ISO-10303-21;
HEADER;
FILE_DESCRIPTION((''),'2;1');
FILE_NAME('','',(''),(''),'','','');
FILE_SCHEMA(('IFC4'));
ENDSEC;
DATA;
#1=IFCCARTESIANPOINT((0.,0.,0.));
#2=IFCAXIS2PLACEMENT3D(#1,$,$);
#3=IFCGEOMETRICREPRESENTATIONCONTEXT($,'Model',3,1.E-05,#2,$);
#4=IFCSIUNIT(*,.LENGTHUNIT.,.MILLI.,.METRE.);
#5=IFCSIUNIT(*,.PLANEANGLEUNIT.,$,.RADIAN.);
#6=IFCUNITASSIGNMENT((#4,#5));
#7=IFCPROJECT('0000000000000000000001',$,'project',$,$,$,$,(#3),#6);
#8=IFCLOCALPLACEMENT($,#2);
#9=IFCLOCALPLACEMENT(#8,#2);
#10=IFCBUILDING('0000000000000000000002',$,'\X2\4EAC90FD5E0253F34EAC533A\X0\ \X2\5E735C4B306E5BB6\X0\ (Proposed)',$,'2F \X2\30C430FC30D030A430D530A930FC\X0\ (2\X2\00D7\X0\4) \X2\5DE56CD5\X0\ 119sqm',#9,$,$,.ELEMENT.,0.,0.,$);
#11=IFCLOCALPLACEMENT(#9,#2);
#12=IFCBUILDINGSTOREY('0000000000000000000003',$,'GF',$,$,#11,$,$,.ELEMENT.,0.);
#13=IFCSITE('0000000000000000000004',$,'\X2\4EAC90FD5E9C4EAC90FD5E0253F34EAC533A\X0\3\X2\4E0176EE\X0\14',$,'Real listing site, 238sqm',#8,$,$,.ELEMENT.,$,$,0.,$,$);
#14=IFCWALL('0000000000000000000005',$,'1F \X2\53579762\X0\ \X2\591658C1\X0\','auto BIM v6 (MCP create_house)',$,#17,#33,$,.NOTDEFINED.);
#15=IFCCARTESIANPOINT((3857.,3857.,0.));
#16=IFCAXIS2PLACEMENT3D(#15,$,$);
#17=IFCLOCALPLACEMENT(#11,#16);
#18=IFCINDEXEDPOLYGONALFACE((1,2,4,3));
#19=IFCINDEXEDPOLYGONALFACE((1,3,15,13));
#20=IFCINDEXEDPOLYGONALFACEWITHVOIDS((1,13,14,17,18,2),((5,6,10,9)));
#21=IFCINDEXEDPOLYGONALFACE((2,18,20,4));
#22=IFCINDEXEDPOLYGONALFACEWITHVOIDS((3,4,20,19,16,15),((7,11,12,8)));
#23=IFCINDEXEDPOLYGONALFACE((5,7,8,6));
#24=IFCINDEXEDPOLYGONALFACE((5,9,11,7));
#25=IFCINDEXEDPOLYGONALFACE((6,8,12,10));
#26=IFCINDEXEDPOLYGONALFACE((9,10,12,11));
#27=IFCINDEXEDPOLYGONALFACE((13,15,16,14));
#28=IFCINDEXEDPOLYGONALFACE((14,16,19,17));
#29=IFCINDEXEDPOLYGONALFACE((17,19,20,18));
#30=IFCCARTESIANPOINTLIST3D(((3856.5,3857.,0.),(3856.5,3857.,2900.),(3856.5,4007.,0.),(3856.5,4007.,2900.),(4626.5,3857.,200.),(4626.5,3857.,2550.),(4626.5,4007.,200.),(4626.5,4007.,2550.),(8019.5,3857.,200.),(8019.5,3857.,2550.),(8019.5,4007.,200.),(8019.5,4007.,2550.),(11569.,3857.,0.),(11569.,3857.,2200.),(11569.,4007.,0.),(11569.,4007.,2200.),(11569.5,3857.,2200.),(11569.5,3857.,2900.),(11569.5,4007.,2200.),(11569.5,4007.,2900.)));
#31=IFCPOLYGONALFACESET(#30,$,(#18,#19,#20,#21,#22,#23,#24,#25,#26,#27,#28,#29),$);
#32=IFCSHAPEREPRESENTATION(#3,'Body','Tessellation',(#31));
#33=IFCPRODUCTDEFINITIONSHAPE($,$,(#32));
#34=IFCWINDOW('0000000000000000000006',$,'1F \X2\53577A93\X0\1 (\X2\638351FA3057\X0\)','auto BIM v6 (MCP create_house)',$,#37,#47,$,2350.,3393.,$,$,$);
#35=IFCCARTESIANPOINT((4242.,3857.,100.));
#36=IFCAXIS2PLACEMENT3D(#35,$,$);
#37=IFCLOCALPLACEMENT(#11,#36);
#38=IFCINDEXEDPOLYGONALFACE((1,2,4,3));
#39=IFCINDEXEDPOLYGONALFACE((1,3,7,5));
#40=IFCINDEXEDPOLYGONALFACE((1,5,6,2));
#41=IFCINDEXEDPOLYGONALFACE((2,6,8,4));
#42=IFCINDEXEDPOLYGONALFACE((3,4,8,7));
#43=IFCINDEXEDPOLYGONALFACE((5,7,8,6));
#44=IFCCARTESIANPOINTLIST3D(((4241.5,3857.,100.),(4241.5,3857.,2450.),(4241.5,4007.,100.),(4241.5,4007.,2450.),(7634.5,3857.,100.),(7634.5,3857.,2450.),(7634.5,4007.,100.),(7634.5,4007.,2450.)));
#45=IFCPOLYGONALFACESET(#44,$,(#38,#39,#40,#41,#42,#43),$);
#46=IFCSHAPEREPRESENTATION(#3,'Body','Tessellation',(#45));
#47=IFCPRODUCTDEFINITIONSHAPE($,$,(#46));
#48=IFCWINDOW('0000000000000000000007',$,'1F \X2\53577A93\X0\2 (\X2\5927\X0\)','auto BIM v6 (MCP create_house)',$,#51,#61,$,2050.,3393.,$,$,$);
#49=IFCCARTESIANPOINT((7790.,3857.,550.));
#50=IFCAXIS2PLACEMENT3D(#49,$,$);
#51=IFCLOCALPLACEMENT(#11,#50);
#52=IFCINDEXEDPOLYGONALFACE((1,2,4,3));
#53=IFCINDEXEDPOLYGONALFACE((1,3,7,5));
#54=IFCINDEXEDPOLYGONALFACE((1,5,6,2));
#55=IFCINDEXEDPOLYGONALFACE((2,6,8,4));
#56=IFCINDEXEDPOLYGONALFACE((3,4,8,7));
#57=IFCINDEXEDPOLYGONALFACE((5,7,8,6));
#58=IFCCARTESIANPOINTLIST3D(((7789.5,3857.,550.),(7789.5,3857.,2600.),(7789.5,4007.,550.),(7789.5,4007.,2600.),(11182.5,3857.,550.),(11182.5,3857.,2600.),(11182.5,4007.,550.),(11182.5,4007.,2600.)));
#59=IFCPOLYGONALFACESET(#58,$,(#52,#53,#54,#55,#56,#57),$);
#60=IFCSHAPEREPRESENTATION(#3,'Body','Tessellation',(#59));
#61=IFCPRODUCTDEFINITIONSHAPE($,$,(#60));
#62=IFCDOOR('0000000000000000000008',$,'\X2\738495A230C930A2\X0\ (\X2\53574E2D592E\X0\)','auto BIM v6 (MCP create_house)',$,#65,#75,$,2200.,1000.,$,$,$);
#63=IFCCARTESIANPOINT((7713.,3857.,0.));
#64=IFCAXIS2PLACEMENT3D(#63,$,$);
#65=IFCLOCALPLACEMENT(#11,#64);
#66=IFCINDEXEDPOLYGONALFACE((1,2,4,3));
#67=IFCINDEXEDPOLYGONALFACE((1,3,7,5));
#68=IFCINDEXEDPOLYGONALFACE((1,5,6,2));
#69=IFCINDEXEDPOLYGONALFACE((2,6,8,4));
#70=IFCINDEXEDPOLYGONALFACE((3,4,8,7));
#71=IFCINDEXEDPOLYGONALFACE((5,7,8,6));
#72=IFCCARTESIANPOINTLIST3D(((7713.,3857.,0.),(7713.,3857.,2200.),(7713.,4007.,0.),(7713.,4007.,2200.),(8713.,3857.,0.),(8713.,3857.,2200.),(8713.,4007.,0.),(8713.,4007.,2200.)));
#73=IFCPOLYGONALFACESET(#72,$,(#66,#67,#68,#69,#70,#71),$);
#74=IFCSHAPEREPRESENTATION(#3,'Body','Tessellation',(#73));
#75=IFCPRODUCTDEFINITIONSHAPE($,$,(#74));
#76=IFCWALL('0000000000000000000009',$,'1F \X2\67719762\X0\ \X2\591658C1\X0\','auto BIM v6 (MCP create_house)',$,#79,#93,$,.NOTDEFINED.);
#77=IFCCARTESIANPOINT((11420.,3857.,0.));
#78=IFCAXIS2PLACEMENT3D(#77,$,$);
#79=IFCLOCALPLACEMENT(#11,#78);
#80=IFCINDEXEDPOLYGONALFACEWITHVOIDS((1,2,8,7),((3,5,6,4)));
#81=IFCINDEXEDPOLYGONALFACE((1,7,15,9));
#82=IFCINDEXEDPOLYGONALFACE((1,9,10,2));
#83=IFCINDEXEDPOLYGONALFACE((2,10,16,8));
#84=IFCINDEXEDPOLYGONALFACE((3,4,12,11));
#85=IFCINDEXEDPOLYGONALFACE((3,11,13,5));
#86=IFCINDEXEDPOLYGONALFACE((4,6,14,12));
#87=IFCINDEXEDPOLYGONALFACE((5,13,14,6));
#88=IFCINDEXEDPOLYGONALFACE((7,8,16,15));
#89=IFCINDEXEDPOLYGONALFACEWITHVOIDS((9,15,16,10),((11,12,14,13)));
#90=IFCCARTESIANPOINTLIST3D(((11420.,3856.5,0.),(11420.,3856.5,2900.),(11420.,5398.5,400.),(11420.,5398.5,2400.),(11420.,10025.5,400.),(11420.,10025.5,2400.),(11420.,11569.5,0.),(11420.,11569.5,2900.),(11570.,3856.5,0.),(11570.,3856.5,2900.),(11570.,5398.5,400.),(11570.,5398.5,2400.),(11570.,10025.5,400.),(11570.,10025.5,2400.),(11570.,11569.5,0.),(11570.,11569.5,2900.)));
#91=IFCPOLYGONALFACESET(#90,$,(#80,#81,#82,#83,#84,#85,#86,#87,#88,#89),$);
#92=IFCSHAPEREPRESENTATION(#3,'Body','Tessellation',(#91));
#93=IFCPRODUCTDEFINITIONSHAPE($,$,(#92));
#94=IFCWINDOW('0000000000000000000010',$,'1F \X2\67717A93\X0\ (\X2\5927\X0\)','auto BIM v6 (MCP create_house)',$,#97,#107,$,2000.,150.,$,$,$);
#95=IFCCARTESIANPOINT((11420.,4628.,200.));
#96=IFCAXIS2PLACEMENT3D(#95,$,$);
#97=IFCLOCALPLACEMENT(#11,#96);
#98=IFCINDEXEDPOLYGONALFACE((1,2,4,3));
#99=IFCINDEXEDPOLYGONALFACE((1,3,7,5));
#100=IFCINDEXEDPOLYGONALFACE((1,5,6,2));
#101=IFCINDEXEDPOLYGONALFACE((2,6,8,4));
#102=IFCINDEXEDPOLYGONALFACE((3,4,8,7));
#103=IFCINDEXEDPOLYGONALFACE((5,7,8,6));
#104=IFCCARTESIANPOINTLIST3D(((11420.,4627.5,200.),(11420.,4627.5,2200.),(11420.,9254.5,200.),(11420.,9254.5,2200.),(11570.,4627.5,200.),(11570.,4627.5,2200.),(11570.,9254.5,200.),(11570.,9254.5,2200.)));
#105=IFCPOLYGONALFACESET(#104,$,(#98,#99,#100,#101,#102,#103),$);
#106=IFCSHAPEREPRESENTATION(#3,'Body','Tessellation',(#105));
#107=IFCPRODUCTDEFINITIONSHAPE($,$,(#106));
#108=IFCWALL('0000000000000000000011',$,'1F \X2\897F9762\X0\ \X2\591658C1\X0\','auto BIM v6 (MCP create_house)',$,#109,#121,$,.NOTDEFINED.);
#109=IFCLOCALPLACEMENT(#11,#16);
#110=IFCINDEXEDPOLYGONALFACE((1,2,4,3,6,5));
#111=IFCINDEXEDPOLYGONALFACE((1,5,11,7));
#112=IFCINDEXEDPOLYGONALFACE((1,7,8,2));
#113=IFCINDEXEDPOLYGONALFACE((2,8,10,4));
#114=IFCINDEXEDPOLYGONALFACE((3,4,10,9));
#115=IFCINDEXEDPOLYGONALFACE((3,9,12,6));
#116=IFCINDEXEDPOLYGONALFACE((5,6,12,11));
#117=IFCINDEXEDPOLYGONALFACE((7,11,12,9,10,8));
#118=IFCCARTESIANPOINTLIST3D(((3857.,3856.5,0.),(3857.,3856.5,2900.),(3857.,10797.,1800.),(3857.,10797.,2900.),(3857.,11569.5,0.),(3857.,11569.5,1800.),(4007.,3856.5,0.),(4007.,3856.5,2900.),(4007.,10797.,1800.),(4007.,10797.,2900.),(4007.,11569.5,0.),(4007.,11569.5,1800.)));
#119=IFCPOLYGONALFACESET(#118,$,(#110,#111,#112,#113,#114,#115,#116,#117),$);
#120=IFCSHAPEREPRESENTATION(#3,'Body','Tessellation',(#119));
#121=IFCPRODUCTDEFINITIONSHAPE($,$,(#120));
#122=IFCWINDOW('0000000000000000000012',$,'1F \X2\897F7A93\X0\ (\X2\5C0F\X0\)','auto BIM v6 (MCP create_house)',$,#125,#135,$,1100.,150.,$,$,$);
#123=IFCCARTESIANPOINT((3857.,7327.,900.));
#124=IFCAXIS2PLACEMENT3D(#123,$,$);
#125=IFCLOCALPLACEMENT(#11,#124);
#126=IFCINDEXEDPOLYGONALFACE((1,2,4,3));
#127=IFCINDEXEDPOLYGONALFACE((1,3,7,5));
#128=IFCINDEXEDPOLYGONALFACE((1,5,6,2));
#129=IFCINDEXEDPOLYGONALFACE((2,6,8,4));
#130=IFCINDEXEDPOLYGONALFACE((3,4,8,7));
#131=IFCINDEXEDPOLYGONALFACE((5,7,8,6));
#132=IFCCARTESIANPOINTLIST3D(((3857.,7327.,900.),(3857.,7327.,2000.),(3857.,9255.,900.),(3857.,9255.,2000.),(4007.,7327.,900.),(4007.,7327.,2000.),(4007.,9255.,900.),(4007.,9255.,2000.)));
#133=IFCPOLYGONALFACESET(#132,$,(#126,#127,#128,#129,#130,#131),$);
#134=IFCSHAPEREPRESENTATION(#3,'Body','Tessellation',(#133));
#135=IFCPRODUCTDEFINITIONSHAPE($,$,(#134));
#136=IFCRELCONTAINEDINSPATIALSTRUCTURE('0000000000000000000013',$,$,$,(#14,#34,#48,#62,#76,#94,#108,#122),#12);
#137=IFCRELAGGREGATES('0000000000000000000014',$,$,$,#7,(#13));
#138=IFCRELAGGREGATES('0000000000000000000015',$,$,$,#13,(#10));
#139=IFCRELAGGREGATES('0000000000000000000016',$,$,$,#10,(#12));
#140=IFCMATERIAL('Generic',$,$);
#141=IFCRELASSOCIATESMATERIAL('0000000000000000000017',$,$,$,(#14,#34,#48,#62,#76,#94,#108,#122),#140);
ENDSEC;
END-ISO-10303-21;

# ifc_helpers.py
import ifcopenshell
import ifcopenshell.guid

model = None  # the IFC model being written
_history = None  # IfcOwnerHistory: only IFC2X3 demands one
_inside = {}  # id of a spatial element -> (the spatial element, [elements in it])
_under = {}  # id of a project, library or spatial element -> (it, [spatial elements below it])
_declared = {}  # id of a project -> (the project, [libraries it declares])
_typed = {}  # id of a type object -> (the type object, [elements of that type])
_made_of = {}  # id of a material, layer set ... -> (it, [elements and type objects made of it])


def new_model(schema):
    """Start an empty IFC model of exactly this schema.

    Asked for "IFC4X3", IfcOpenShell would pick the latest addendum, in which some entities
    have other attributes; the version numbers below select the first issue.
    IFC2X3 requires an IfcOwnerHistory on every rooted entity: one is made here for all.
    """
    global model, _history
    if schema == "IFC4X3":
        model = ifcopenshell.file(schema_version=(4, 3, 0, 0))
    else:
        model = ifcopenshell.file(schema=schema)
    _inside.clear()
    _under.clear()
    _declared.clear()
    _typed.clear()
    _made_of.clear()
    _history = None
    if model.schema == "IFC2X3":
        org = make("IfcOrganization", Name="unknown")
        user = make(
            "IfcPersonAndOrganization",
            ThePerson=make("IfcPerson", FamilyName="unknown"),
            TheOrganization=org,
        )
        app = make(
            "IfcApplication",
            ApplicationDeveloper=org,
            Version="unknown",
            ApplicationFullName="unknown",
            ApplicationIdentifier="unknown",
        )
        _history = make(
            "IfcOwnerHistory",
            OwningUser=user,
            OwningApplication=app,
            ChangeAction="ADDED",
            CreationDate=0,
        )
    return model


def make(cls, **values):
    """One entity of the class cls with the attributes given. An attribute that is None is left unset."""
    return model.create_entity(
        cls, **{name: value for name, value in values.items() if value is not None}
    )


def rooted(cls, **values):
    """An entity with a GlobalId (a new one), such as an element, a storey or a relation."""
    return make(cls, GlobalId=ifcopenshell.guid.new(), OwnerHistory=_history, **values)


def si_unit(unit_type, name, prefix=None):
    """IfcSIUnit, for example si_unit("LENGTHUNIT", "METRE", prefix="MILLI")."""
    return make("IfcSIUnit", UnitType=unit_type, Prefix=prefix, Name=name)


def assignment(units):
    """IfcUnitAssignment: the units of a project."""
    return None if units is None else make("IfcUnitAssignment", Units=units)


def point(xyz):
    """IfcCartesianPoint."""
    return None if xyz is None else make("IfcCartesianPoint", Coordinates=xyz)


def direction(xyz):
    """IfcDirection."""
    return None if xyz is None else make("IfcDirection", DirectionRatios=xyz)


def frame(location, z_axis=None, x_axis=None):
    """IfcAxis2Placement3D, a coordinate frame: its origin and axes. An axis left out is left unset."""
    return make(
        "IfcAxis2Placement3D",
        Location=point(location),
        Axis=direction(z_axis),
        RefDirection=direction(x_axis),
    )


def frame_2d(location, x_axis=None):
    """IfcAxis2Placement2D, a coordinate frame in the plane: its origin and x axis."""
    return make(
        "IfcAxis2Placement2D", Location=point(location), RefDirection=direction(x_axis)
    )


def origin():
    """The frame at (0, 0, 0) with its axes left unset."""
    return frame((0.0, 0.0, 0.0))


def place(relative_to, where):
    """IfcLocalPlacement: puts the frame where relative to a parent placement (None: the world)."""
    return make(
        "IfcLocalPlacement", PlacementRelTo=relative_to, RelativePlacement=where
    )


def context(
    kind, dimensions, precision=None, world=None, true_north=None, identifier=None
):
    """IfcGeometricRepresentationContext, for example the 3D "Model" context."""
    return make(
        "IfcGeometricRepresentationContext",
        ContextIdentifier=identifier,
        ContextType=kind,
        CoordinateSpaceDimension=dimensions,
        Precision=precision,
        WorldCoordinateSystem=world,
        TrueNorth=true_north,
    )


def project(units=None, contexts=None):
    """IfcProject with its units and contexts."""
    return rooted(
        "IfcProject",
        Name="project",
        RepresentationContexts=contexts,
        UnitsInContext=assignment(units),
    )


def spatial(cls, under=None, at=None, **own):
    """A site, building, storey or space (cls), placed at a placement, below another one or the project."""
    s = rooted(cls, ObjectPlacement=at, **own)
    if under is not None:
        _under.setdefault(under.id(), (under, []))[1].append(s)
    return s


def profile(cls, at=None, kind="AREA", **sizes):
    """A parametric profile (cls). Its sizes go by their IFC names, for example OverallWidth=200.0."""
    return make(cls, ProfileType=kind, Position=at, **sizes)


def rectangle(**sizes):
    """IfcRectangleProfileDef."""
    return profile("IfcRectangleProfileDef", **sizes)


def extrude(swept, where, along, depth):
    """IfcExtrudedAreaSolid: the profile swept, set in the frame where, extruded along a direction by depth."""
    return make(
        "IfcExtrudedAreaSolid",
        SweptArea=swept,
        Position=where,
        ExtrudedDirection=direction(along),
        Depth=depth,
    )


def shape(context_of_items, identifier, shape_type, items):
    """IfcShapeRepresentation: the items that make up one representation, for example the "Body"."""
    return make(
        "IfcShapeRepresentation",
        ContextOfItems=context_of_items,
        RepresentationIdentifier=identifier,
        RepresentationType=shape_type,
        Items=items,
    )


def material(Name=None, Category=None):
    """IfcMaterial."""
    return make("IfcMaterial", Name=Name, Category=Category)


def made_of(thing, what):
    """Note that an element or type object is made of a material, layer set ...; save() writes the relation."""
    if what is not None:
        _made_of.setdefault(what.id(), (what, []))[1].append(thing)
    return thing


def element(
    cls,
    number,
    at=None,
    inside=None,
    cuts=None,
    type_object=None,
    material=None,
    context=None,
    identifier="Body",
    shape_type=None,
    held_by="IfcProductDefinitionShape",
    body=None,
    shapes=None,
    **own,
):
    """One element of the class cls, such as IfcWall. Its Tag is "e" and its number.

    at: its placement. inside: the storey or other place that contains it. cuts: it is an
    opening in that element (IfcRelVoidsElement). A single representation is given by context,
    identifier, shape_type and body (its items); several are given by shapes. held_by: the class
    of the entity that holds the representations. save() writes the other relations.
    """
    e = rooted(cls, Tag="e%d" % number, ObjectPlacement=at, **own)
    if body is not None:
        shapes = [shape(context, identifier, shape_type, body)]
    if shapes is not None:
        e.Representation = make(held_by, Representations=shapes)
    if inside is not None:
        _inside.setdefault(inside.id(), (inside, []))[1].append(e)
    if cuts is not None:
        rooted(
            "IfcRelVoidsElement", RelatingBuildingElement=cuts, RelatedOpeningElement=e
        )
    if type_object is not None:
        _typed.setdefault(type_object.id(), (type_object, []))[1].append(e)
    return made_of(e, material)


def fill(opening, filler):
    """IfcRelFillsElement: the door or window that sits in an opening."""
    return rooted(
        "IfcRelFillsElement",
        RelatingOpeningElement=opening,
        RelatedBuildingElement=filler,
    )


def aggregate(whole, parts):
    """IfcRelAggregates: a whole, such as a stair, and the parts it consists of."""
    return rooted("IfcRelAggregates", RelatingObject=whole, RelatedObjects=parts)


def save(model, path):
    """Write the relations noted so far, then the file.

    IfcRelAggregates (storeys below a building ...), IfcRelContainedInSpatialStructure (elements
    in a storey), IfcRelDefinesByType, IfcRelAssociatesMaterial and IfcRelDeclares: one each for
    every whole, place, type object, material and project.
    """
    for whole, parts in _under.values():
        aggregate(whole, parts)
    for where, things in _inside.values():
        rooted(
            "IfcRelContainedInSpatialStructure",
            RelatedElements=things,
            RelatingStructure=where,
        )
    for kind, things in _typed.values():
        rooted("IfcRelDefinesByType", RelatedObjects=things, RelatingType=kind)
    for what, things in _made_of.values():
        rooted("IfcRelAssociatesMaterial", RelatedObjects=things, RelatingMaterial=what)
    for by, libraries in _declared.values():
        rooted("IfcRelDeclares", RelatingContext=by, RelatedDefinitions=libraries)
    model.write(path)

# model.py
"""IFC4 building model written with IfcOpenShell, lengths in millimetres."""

from ifc_helpers import new_model, si_unit, frame, frame_2d, origin, place, context, project, spatial, rectangle, extrude, material, element, fill, save


model = new_model("IFC4")

# Units and contexts
model_context = context("Model", 3, precision=1e-05, world=origin())
ifc_project = project(units=[si_unit("LENGTHUNIT", "METRE", prefix="MILLI"), si_unit("PLANEANGLEUNIT", "RADIAN")], contexts=[model_context])

# Site, building, storey
site_placement = place(None, origin())
site = spatial("IfcSite", under=ifc_project, at=site_placement, Name="京都府京都市右京区3丁目14", ObjectType="Real listing site, 238sqm", CompositionType="ELEMENT", RefElevation=0.0)
building_placement = place(site_placement, origin())
building = spatial("IfcBuilding", under=site, at=building_placement, Name="京都市右京区 平屋の家 (Proposed)", ObjectType="2F ツーバイフォー (2×4) 工法 119sqm", CompositionType="ELEMENT", ElevationOfRefHeight=0.0, ElevationOfTerrain=0.0)
storey_placement = place(building_placement, origin())
storey = spatial("IfcBuildingStorey", under=building, at=storey_placement, Name="GF", CompositionType="ELEMENT", Elevation=0.0)

# Shared definitions
ifc_material = material(Name="Generic")

# Wall, openings, windows, door
wall_1_placement = place(storey_placement, frame((3857.0, 3857.0, 0.0)))
wall_1 = element("IfcWall", 1, at=wall_1_placement, inside=storey, material=ifc_material, Name="1F 南面 外壁", Description="auto BIM v6 (MCP create_house)", PredefinedType="NOTDEFINED", context=model_context, shape_type="SweptSolid", body=[
    extrude(rectangle(XDim=7713.0, YDim=150.0, at=frame_2d((3856.0, 75.0))), frame((3857.0, 3857.0, 0.0)), (0.0, 0.0, 1.0), 2900.0),
])
opening_1_placement = place(storey_placement, frame((4242.0, 3857.0, 100.0)))
opening_1 = element("IfcOpeningElement", 2, at=opening_1_placement, cuts=wall_1, PredefinedType="NOTDEFINED", context=model_context, shape_type="SweptSolid", body=[
    extrude(rectangle(XDim=3393.0, YDim=150.0, at=frame_2d((1696.0, 75.0))), frame((4242.0, 3857.0, 100.0)), (0.0, 0.0, 1.0), 2350.0),
])
opening_2_placement = place(storey_placement, frame((7790.0, 3857.0, 550.0)))
opening_2 = element("IfcOpeningElement", 3, at=opening_2_placement, cuts=wall_1, PredefinedType="NOTDEFINED", context=model_context, shape_type="SweptSolid", body=[
    extrude(rectangle(XDim=3393.0, YDim=150.0, at=frame_2d((1696.0, 75.0))), frame((7790.0, 3857.0, 550.0)), (0.0, 0.0, 1.0), 2050.0),
])
opening_3_placement = place(storey_placement, frame((7713.0, 3857.0, 0.0)))
opening_3 = element("IfcOpeningElement", 4, at=opening_3_placement, cuts=wall_1, PredefinedType="NOTDEFINED", context=model_context, shape_type="SweptSolid", body=[
    extrude(rectangle(XDim=1000.0, YDim=150.0, at=frame_2d((500.0, 75.0))), frame((7713.0, 3857.0, 0.0)), (0.0, 0.0, 1.0), 2200.0),
])
window_1_placement = place(storey_placement, frame((4242.0, 3857.0, 100.0)))
window_1 = element("IfcWindow", 5, at=window_1_placement, inside=storey, material=ifc_material, Name="1F 南窓1 (掃出し)", Description="auto BIM v6 (MCP create_house)", OverallHeight=2350.0, OverallWidth=3393.0, context=model_context, shape_type="SweptSolid", body=[
    extrude(rectangle(XDim=3393.0, YDim=150.0, at=frame_2d((1696.0, 75.0))), frame((4242.0, 3857.0, 100.0)), (0.0, 0.0, 1.0), 2350.0),
])
fill(opening_1, window_1)
window_2_placement = place(storey_placement, frame((7790.0, 3857.0, 550.0)))
window_2 = element("IfcWindow", 6, at=window_2_placement, inside=storey, material=ifc_material, Name="1F 南窓2 (大)", Description="auto BIM v6 (MCP create_house)", OverallHeight=2050.0, OverallWidth=3393.0, context=model_context, shape_type="SweptSolid", body=[
    extrude(rectangle(XDim=3393.0, YDim=150.0, at=frame_2d((1696.0, 75.0))), frame((7790.0, 3857.0, 550.0)), (0.0, 0.0, 1.0), 2050.0),
])
fill(opening_2, window_2)
door_placement = place(storey_placement, frame((7713.0, 3857.0, 0.0)))
door = element("IfcDoor", 7, at=door_placement, inside=storey, material=ifc_material, Name="玄関ドア (南中央)", Description="auto BIM v6 (MCP create_house)", OverallHeight=2200.0, OverallWidth=1000.0, context=model_context, shape_type="SweptSolid", body=[
    extrude(rectangle(XDim=1000.0, YDim=150.0, at=frame_2d((500.0, 75.0))), frame((7713.0, 3857.0, 0.0)), (0.0, 0.0, 1.0), 2200.0),
])
fill(opening_3, door)

# Walls, openings, windows
wall_2_placement = place(storey_placement, frame((11420.0, 3857.0, 0.0)))
wall_2 = element("IfcWall", 8, at=wall_2_placement, inside=storey, material=ifc_material, Name="1F 東面 外壁", Description="auto BIM v6 (MCP create_house)", PredefinedType="NOTDEFINED", context=model_context, shape_type="SweptSolid", body=[
    extrude(rectangle(XDim=150.0, YDim=7713.0, at=frame_2d((75.0, 3856.0))), frame((11420.0, 3857.0, 0.0)), (0.0, 0.0, 1.0), 2900.0),
])
opening_4_placement = place(storey_placement, frame((11420.0, 4628.0, 200.0)))
opening_4 = element("IfcOpeningElement", 9, at=opening_4_placement, cuts=wall_2, PredefinedType="NOTDEFINED", context=model_context, shape_type="SweptSolid", body=[
    extrude(rectangle(XDim=150.0, YDim=4627.0, at=frame_2d((75.0, 2313.0))), frame((11420.0, 4628.0, 200.0)), (0.0, 0.0, 1.0), 2000.0),
])
window_3_placement = place(storey_placement, frame((11420.0, 4628.0, 200.0)))
window_3 = element("IfcWindow", 10, at=window_3_placement, inside=storey, material=ifc_material, Name="1F 東窓 (大)", Description="auto BIM v6 (MCP create_house)", OverallHeight=2000.0, OverallWidth=150.0, context=model_context, shape_type="SweptSolid", body=[
    extrude(rectangle(XDim=150.0, YDim=4627.0, at=frame_2d((75.0, 2313.0))), frame((11420.0, 4628.0, 200.0)), (0.0, 0.0, 1.0), 2000.0),
])
fill(opening_4, window_3)
wall_3_placement = place(storey_placement, frame((3857.0, 3857.0, 0.0)))
wall_3 = element("IfcWall", 11, at=wall_3_placement, inside=storey, material=ifc_material, Name="1F 西面 外壁", Description="auto BIM v6 (MCP create_house)", PredefinedType="NOTDEFINED", context=model_context, shape_type="SweptSolid", body=[
    extrude(rectangle(XDim=150.0, YDim=7713.0, at=frame_2d((75.0, 3856.0))), frame((3857.0, 3857.0, 0.0)), (0.0, 0.0, 1.0), 2900.0),
])
opening_5_placement = place(storey_placement, frame((3857.0, 7327.0, 900.0)))
opening_5 = element("IfcOpeningElement", 12, at=opening_5_placement, cuts=wall_3, PredefinedType="NOTDEFINED", context=model_context, shape_type="SweptSolid", body=[
    extrude(rectangle(XDim=150.0, YDim=1928.0, at=frame_2d((75.0, 964.0))), frame((3857.0, 7327.0, 900.0)), (0.0, 0.0, 1.0), 1100.0),
])
window_4_placement = place(storey_placement, frame((3857.0, 7327.0, 900.0)))
window_4 = element("IfcWindow", 13, at=window_4_placement, inside=storey, material=ifc_material, Name="1F 西窓 (小)", Description="auto BIM v6 (MCP create_house)", OverallHeight=1100.0, OverallWidth=150.0, context=model_context, shape_type="SweptSolid", body=[
    extrude(rectangle(XDim=150.0, YDim=1928.0, at=frame_2d((75.0, 964.0))), frame((3857.0, 7327.0, 900.0)), (0.0, 0.0, 1.0), 1100.0),
])
fill(opening_5, window_4)

save(model, "model.ifc")
